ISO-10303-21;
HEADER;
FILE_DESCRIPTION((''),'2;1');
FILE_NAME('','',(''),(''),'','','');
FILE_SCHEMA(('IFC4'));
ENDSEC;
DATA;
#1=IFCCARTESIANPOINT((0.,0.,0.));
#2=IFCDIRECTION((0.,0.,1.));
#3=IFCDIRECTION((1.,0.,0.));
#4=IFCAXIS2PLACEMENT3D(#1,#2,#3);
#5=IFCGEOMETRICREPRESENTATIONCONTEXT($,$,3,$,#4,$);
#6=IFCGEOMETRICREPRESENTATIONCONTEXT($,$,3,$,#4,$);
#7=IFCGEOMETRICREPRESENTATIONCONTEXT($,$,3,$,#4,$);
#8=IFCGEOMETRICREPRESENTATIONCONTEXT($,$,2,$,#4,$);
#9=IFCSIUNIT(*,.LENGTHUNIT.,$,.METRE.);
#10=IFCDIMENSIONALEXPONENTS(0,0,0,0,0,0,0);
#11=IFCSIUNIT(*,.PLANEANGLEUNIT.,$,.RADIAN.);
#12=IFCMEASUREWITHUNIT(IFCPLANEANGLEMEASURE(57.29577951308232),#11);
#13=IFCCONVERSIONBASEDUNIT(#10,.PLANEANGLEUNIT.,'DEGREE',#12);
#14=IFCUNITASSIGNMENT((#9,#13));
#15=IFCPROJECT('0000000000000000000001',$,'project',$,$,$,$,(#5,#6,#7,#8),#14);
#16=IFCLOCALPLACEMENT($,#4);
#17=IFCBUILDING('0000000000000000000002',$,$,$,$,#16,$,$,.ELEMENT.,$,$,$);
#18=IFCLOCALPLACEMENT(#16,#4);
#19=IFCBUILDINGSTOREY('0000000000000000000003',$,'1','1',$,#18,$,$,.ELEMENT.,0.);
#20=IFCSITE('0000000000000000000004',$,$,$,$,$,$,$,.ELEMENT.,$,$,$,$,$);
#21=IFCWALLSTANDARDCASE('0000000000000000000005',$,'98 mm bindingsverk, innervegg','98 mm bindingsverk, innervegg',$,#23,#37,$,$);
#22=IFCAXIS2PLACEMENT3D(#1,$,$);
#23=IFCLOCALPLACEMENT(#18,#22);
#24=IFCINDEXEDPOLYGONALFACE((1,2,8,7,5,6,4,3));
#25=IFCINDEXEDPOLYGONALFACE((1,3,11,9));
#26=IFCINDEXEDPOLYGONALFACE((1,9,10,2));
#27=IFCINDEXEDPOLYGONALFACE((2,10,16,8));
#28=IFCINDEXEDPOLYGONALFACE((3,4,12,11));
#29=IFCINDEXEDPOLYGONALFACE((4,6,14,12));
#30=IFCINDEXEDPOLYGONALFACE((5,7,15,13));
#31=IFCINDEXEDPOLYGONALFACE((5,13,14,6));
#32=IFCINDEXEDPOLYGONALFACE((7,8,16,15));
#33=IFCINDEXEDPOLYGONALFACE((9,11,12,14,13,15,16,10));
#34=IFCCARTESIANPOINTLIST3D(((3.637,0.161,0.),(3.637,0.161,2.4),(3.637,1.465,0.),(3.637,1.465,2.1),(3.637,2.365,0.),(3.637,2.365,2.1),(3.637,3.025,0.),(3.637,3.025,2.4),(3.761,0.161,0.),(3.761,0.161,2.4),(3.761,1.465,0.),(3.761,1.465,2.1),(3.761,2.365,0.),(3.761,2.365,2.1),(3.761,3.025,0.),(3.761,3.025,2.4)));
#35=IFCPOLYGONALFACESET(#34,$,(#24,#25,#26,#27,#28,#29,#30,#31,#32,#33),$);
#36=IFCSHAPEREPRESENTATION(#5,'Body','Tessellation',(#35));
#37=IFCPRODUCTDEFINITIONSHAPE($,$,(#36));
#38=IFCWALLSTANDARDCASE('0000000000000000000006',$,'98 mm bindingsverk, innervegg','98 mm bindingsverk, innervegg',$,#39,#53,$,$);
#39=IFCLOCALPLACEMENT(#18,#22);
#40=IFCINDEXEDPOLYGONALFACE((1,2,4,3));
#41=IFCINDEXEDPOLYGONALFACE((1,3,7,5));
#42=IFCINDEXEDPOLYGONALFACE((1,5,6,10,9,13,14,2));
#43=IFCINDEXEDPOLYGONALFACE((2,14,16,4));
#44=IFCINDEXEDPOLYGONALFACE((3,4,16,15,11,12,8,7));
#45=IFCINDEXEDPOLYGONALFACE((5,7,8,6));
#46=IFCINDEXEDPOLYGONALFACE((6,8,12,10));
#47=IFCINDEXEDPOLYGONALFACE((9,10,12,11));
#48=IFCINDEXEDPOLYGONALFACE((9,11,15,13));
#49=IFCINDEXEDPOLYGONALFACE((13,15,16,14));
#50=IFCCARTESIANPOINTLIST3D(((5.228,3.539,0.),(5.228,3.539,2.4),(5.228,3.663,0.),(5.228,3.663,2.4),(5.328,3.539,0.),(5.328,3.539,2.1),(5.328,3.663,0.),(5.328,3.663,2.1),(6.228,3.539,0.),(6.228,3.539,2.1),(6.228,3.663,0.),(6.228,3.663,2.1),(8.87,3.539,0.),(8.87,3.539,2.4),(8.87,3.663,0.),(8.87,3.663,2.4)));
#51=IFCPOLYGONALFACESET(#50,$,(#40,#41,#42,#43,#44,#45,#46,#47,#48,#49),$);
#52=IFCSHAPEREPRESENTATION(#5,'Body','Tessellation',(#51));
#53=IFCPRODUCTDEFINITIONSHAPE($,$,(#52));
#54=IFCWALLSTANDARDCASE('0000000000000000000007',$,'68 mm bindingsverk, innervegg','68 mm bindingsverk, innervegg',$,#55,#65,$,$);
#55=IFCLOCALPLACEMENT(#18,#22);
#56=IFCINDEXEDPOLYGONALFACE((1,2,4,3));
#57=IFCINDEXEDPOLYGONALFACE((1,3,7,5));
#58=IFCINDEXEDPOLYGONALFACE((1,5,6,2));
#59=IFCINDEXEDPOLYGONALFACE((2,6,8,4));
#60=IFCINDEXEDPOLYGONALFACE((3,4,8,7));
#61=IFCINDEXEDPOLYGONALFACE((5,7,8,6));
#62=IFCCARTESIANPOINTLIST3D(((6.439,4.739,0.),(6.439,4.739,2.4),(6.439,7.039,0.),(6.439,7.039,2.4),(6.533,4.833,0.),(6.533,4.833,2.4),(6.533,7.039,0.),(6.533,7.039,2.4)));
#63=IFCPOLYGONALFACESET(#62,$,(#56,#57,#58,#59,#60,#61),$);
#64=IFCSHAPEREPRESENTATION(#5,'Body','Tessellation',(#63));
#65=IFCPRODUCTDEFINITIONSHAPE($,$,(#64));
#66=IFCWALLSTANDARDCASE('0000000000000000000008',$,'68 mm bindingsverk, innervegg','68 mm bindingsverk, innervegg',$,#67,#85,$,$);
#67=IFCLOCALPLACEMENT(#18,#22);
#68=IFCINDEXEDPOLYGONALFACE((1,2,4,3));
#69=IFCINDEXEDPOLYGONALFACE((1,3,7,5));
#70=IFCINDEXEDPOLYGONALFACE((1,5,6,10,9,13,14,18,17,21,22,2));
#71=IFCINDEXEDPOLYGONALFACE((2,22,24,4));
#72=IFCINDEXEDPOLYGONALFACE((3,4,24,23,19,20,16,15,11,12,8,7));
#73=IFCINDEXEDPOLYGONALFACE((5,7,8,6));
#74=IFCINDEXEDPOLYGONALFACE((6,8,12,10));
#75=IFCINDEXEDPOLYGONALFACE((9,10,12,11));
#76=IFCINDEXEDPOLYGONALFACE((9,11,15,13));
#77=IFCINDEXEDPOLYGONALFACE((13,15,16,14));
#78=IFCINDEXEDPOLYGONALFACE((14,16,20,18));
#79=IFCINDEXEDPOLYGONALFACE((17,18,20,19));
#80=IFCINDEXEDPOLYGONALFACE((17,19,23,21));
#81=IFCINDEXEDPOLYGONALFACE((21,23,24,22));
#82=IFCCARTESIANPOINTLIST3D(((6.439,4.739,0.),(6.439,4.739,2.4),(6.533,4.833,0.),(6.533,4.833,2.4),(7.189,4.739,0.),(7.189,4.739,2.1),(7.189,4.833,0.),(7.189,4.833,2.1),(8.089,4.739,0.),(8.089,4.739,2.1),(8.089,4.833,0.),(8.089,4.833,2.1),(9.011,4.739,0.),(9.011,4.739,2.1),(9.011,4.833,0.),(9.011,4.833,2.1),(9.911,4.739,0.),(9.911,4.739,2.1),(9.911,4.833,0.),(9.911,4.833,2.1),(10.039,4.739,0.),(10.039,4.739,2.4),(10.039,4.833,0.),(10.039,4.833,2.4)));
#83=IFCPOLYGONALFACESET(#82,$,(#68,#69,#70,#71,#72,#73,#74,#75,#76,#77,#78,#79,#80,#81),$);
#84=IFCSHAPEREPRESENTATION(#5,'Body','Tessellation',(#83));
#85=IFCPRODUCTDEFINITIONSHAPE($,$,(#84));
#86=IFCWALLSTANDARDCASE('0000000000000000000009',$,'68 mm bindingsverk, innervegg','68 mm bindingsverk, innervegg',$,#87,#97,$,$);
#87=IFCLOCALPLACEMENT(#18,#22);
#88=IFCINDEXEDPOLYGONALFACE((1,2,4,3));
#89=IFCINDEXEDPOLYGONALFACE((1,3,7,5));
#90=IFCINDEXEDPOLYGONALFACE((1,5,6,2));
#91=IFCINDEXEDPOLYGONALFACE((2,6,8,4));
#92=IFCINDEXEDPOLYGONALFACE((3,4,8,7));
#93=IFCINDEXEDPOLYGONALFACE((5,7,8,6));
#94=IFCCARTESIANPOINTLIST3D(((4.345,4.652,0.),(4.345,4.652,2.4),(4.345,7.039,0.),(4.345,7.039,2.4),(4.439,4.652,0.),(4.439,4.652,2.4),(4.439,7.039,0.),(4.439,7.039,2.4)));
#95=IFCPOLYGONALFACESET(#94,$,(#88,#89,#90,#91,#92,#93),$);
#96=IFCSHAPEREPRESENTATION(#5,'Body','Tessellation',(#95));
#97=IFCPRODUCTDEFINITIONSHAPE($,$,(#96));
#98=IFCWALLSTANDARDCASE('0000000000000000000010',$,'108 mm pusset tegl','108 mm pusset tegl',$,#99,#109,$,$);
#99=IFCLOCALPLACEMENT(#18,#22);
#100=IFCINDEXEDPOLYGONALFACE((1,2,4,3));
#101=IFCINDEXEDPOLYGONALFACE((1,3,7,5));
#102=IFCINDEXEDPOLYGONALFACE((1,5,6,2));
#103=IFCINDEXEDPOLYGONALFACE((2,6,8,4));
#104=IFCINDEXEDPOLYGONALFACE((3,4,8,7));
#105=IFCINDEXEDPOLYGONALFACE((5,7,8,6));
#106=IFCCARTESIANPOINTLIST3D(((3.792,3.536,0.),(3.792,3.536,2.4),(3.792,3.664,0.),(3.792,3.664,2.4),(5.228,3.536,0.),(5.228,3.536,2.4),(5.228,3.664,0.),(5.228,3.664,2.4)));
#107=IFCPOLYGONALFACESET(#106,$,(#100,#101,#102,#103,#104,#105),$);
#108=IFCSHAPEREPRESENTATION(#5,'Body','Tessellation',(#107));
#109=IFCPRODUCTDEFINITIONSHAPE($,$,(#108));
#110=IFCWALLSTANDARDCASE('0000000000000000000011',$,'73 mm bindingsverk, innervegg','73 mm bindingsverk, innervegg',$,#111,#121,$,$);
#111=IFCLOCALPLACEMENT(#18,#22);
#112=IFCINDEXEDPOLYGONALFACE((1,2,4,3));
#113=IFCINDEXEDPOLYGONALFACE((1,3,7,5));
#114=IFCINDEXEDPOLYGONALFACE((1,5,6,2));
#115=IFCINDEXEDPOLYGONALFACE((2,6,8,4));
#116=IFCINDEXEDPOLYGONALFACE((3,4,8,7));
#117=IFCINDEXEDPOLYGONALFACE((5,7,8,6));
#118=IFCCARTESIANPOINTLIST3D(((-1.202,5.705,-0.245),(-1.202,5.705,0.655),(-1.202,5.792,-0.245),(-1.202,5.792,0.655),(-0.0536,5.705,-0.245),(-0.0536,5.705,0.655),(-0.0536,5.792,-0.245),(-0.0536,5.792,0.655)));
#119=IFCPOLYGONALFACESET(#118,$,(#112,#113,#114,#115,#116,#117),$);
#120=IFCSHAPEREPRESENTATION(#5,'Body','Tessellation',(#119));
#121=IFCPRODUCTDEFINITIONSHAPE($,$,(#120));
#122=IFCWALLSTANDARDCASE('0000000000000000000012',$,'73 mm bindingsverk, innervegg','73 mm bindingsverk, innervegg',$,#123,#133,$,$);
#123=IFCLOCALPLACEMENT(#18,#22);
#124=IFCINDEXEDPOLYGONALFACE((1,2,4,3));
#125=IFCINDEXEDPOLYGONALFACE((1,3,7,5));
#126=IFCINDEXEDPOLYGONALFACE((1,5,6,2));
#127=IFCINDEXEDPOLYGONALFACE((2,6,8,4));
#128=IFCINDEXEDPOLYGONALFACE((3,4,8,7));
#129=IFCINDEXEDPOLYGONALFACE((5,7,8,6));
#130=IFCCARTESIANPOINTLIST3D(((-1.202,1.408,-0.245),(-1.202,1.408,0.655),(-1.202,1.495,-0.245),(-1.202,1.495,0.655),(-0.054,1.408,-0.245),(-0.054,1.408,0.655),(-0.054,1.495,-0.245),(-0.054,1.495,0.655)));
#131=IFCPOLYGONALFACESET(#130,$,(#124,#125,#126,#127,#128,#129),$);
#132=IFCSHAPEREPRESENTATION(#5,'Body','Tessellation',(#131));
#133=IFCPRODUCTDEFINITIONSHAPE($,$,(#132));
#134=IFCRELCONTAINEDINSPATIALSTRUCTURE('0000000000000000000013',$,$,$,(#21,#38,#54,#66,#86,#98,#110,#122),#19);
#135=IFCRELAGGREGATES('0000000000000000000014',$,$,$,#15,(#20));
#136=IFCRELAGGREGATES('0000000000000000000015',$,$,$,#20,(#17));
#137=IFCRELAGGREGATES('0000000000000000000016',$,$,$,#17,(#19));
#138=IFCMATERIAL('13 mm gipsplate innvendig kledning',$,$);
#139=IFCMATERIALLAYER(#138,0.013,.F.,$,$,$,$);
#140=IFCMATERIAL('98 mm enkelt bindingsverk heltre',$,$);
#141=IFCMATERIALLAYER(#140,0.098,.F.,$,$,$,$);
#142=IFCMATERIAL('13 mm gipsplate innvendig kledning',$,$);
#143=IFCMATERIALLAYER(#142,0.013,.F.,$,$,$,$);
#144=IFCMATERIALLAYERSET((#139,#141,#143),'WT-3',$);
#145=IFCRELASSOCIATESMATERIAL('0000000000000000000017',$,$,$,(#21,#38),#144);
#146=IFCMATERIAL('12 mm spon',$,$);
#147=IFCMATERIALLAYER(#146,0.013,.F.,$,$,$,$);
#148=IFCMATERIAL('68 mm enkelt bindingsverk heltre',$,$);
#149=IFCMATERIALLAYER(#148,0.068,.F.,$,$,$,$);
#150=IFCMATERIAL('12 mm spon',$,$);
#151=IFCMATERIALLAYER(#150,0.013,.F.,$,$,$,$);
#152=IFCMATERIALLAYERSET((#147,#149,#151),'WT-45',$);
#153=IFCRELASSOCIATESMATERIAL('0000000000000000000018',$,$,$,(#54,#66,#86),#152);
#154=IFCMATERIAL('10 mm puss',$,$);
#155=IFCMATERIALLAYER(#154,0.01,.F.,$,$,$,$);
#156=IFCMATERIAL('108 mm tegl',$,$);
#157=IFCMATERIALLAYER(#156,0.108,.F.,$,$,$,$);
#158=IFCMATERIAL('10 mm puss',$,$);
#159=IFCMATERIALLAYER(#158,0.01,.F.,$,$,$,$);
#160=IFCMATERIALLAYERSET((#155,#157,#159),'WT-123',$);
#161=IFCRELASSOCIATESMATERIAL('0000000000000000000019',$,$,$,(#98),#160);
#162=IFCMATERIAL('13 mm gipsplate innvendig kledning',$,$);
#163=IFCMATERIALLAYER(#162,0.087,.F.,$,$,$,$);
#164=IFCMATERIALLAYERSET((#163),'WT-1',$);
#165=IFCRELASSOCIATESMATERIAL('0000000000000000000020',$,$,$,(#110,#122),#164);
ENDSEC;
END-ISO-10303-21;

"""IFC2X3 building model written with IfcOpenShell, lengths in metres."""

from ifc_helpers import new_model, entity, si_unit, converted_unit, frame, origin_with_axes, place, context, project, spatial, polyline, outline, extrude, material, layer, layer_set, layer_usage, element, save


model = new_model("IFC2X3")

# Units and contexts
context_of_model_1 = context(None, 3, world=origin_with_axes())
context_of_model_2 = context(None, 3, world=origin_with_axes())
context_of_model_3 = context(None, 3, world=origin_with_axes())
context_of_model_4 = context(None, 2, world=origin_with_axes())
ifc_project = project(units=[si_unit("LENGTHUNIT", "METRE"), converted_unit("PLANEANGLEUNIT", "DEGREE", entity("IfcPlaneAngleMeasure", 57.29577951308232), si_unit("PLANEANGLEUNIT", "RADIAN"), dimensions=[0, 0, 0, 0, 0, 0, 0])], contexts=[context_of_model_1, context_of_model_2, context_of_model_3, context_of_model_4])

# Site, building, storey
site = spatial("IfcSite", under=ifc_project, CompositionType="ELEMENT")
building_placement = place(None, origin_with_axes())
building = spatial("IfcBuilding", under=site, at=building_placement, CompositionType="ELEMENT")
storey_placement = place(building_placement, origin_with_axes())
storey = spatial("IfcBuildingStorey", under=building, at=storey_placement, Name="1", Description="1", CompositionType="ELEMENT", Elevation=0.0)

# Walls, openings
ifc_material_1 = material(Name="13 mm gipsplate innvendig kledning")
ifc_layer_1 = layer(ifc_material_1, 0.013, ventilated=False)
ifc_material_2 = material(Name="98 mm enkelt bindingsverk heltre")
ifc_layer_2 = layer(ifc_material_2, 0.098, ventilated=False)
ifc_material_3 = material(Name="13 mm gipsplate innvendig kledning")
ifc_layer_3 = layer(ifc_material_3, 0.013, ventilated=False)
ifc_layer_set_1 = layer_set([ifc_layer_1, ifc_layer_2, ifc_layer_3], Name="WT-3")
ifc_layer_usage_1 = layer_usage(ifc_layer_set_1, "AXIS2", "POSITIVE", 0.0)
wall_1_placement = place(storey_placement, frame((3.761, 0.161, 0.0), z_axis=(0.0, 0.0, 1.0), x_axis=(0.0, 1.0, 0.0)))
wall_1 = element("IfcWallStandardCase", 1, at=wall_1_placement, inside=storey, material=ifc_layer_usage_1, Name="98 mm bindingsverk, innervegg", Description="98 mm bindingsverk, innervegg", context=context_of_model_1, shape_type="SweptSolid", body=[
    extrude(outline(polyline([(0.0, 0.0), (2.864, 0.0), (2.864, 0.124), (0.0, 0.124), (0.0, 0.0)])), frame((0.0, 0.0, 0.0), z_axis=(0.0, 0.0, 1.0), x_axis=(1.0, 0.0, 0.0)), (0.0, 0.0, 1.0), 2.4),
])
opening_1_placement = place(wall_1_placement, frame((1.304, 0.0, 0.0), z_axis=(0.0, 0.0, 1.0), x_axis=(1.0, 0.0, 0.0)))
element("IfcOpeningElement", 2, at=opening_1_placement, inside=storey, cuts=wall_1, context=context_of_model_1, shape_type="SweptSolid", body=[
    extrude(outline(polyline([(0.0, 0.0), (2.1, 0.0), (2.1, 0.9), (0.0, 0.9), (0.0, 0.0)])), frame((0.0, 0.0, 0.0), z_axis=(0.0, 1.0, 0.0), x_axis=(0.0, 0.0, 1.0)), (0.0, 0.0, 1.0), 0.124),
])
wall_2_placement = place(storey_placement, frame((5.228, 3.539, 0.0), z_axis=(0.0, 0.0, 1.0), x_axis=(1.0, 0.0, 0.0)))
wall_2 = element("IfcWallStandardCase", 3, at=wall_2_placement, inside=storey, material=ifc_layer_usage_1, Name="98 mm bindingsverk, innervegg", Description="98 mm bindingsverk, innervegg", context=context_of_model_1, shape_type="SweptSolid", body=[
    extrude(outline(polyline([(0.0, 0.0), (3.642, 0.0), (3.642, 0.124), (0.0, 0.124), (0.0, 0.0)])), origin_with_axes(), (0.0, 0.0, 1.0), 2.4),
])
opening_2_placement = place(wall_2_placement, frame((0.1, 0.0, 0.0), z_axis=(0.0, 0.0, 1.0), x_axis=(1.0, 0.0, 0.0)))
element("IfcOpeningElement", 4, at=opening_2_placement, inside=storey, cuts=wall_2, context=context_of_model_1, shape_type="SweptSolid", body=[
    extrude(outline(polyline([(0.0, 0.0), (2.1, 0.0), (2.1, 0.9), (0.0, 0.9), (0.0, 0.0)])), frame((0.0, 0.0, 0.0), z_axis=(0.0, 1.0, 0.0), x_axis=(0.0, 0.0, 1.0)), (0.0, 0.0, 1.0), 0.124),
])

# Wall
ifc_material_4 = material(Name="12 mm spon")
ifc_layer_4 = layer(ifc_material_4, 0.013, ventilated=False)
ifc_material_5 = material(Name="68 mm enkelt bindingsverk heltre")
ifc_layer_5 = layer(ifc_material_5, 0.068, ventilated=False)
ifc_material_6 = material(Name="12 mm spon")
ifc_layer_6 = layer(ifc_material_6, 0.013, ventilated=False)
ifc_layer_set_2 = layer_set([ifc_layer_4, ifc_layer_5, ifc_layer_6], Name="WT-45")
ifc_layer_usage_2 = layer_usage(ifc_layer_set_2, "AXIS2", "POSITIVE", 0.0)
wall_3_placement = place(storey_placement, frame((6.439, 7.039, 0.0), z_axis=(0.0, 0.0, 1.0), x_axis=(0.0, -1.0, 0.0)))
element("IfcWallStandardCase", 5, at=wall_3_placement, inside=storey, material=ifc_layer_usage_2, Name="68 mm bindingsverk, innervegg", Description="68 mm bindingsverk, innervegg", context=context_of_model_1, shape_type="SweptSolid", body=[
    extrude(outline(polyline([(0.0, 0.0), (2.3, 0.0), (2.206, 0.094), (0.0, 0.094), (0.0, 0.0)])), frame((0.0, 0.0, 0.0), z_axis=(0.0, 0.0, 1.0), x_axis=(1.0, 0.0, 0.0)), (0.0, 0.0, 1.0), 2.4),
])

# Wall, openings
wall_4_placement = place(storey_placement, frame((6.439, 4.739, 0.0), z_axis=(0.0, 0.0, 1.0), x_axis=(1.0, 0.0, 0.0)))
wall_4 = element("IfcWallStandardCase", 6, at=wall_4_placement, inside=storey, material=ifc_layer_usage_2, Name="68 mm bindingsverk, innervegg", Description="68 mm bindingsverk, innervegg", context=context_of_model_1, shape_type="SweptSolid", body=[
    extrude(outline(polyline([(0.0, 0.0), (3.6, 0.0), (3.6, 0.094), (0.094, 0.094), (0.0, 0.0)])), origin_with_axes(), (0.0, 0.0, 1.0), 2.4),
])
opening_3_placement = place(wall_4_placement, frame((0.75, 0.0, 0.0), z_axis=(0.0, 0.0, 1.0), x_axis=(1.0, 0.0, 0.0)))
element("IfcOpeningElement", 7, at=opening_3_placement, inside=storey, cuts=wall_4, context=context_of_model_1, shape_type="SweptSolid", body=[
    extrude(outline(polyline([(0.0, 0.0), (2.1, 0.0), (2.1, 0.9), (0.0, 0.9), (0.0, 0.0)])), frame((0.0, 0.0, 0.0), z_axis=(0.0, 1.0, 0.0), x_axis=(0.0, 0.0, 1.0)), (0.0, 0.0, 1.0), 0.094),
])
opening_4_placement = place(wall_4_placement, frame((2.572, 0.0, 0.0), z_axis=(0.0, 0.0, 1.0), x_axis=(1.0, 0.0, 0.0)))
element("IfcOpeningElement", 8, at=opening_4_placement, inside=storey, cuts=wall_4, context=context_of_model_1, shape_type="SweptSolid", body=[
    extrude(outline(polyline([(0.0, 0.0), (2.1, 0.0), (2.1, 0.9), (0.0, 0.9), (0.0, 0.0)])), frame((0.0, 0.0, 0.0), z_axis=(0.0, 1.0, 0.0), x_axis=(0.0, 0.0, 1.0)), (0.0, 0.0, 1.0), 0.094),
])

# Walls
wall_5_placement = place(storey_placement, frame((4.345, 7.039, 0.0), z_axis=(0.0, 0.0, 1.0), x_axis=(0.0, -1.0, 0.0)))
element("IfcWallStandardCase", 9, at=wall_5_placement, inside=storey, material=ifc_layer_usage_2, Name="68 mm bindingsverk, innervegg", Description="68 mm bindingsverk, innervegg", context=context_of_model_1, shape_type="SweptSolid", body=[
    extrude(outline(polyline([(0.0, 0.0), (2.387, 0.0), (2.387, 0.094), (0.0, 0.094), (0.0, 0.0)])), frame((0.0, 0.0, 0.0), z_axis=(0.0, 0.0, 1.0), x_axis=(1.0, 0.0, 0.0)), (0.0, 0.0, 1.0), 2.4),
])
ifc_material_7 = material(Name="10 mm puss")
ifc_layer_7 = layer(ifc_material_7, 0.01, ventilated=False)
ifc_material_8 = material(Name="108 mm tegl")
ifc_layer_8 = layer(ifc_material_8, 0.108, ventilated=False)
ifc_material_9 = material(Name="10 mm puss")
ifc_layer_9 = layer(ifc_material_9, 0.01, ventilated=False)
ifc_layer_set_3 = layer_set([ifc_layer_7, ifc_layer_8, ifc_layer_9], Name="WT-123")
ifc_layer_usage_3 = layer_usage(ifc_layer_set_3, "AXIS2", "POSITIVE", 0.0)
wall_6_placement = place(storey_placement, frame((5.228, 3.664, 0.0), z_axis=(0.0, 0.0, 1.0), x_axis=(-1.0, 0.0, 0.0)))
element("IfcWallStandardCase", 10, at=wall_6_placement, inside=storey, material=ifc_layer_usage_3, Name="108 mm pusset tegl", Description="108 mm pusset tegl", context=context_of_model_1, shape_type="SweptSolid", body=[
    extrude(outline(polyline([(0.0, 0.0), (1.436, 0.0), (1.436, 0.128), (0.0, 0.128), (0.0, 0.0)])), frame((0.0, 0.0, 0.0), z_axis=(0.0, 0.0, 1.0), x_axis=(1.0, 0.0, 0.0)), (0.0, 0.0, 1.0), 2.4),
])
ifc_material_10 = material(Name="13 mm gipsplate innvendig kledning")
ifc_layer_10 = layer(ifc_material_10, 0.087, ventilated=False)
ifc_layer_set_4 = layer_set([ifc_layer_10], Name="WT-1")
ifc_layer_usage_4 = layer_usage(ifc_layer_set_4, "AXIS2", "POSITIVE", 0.0)
wall_7_placement = place(storey_placement, frame((-0.0536, 5.792, -0.245), z_axis=(0.0, 0.0, 1.0), x_axis=(-1.0, 0.0, 0.0)))
element("IfcWallStandardCase", 11, at=wall_7_placement, inside=storey, material=ifc_layer_usage_4, Name="73 mm bindingsverk, innervegg", Description="73 mm bindingsverk, innervegg", context=context_of_model_1, shape_type="SweptSolid", body=[
    extrude(outline(polyline([(0.0, 0.0), (1.1484, 0.0), (1.1484, 0.087), (0.0, 0.087), (0.0, 0.0)])), frame((0.0, 0.0, 0.0), z_axis=(0.0, 0.0, 1.0), x_axis=(1.0, 0.0, 0.0)), (0.0, 0.0, 1.0), 0.9),
])
wall_8_placement = place(storey_placement, frame((-1.202, 1.408, -0.245), z_axis=(0.0, 0.0, 1.0), x_axis=(1.0, 0.0, 0.0)))
element("IfcWallStandardCase", 12, at=wall_8_placement, inside=storey, material=ifc_layer_usage_4, Name="73 mm bindingsverk, innervegg", Description="73 mm bindingsverk, innervegg", context=context_of_model_1, shape_type="SweptSolid", body=[
    extrude(outline(polyline([(0.0, 0.0), (1.148, 0.0), (1.148, 0.087), (0.0, 0.087), (0.0, 0.0)])), origin_with_axes(), (0.0, 0.0, 1.0), 0.9),
])

save(model, "model.ifc")
